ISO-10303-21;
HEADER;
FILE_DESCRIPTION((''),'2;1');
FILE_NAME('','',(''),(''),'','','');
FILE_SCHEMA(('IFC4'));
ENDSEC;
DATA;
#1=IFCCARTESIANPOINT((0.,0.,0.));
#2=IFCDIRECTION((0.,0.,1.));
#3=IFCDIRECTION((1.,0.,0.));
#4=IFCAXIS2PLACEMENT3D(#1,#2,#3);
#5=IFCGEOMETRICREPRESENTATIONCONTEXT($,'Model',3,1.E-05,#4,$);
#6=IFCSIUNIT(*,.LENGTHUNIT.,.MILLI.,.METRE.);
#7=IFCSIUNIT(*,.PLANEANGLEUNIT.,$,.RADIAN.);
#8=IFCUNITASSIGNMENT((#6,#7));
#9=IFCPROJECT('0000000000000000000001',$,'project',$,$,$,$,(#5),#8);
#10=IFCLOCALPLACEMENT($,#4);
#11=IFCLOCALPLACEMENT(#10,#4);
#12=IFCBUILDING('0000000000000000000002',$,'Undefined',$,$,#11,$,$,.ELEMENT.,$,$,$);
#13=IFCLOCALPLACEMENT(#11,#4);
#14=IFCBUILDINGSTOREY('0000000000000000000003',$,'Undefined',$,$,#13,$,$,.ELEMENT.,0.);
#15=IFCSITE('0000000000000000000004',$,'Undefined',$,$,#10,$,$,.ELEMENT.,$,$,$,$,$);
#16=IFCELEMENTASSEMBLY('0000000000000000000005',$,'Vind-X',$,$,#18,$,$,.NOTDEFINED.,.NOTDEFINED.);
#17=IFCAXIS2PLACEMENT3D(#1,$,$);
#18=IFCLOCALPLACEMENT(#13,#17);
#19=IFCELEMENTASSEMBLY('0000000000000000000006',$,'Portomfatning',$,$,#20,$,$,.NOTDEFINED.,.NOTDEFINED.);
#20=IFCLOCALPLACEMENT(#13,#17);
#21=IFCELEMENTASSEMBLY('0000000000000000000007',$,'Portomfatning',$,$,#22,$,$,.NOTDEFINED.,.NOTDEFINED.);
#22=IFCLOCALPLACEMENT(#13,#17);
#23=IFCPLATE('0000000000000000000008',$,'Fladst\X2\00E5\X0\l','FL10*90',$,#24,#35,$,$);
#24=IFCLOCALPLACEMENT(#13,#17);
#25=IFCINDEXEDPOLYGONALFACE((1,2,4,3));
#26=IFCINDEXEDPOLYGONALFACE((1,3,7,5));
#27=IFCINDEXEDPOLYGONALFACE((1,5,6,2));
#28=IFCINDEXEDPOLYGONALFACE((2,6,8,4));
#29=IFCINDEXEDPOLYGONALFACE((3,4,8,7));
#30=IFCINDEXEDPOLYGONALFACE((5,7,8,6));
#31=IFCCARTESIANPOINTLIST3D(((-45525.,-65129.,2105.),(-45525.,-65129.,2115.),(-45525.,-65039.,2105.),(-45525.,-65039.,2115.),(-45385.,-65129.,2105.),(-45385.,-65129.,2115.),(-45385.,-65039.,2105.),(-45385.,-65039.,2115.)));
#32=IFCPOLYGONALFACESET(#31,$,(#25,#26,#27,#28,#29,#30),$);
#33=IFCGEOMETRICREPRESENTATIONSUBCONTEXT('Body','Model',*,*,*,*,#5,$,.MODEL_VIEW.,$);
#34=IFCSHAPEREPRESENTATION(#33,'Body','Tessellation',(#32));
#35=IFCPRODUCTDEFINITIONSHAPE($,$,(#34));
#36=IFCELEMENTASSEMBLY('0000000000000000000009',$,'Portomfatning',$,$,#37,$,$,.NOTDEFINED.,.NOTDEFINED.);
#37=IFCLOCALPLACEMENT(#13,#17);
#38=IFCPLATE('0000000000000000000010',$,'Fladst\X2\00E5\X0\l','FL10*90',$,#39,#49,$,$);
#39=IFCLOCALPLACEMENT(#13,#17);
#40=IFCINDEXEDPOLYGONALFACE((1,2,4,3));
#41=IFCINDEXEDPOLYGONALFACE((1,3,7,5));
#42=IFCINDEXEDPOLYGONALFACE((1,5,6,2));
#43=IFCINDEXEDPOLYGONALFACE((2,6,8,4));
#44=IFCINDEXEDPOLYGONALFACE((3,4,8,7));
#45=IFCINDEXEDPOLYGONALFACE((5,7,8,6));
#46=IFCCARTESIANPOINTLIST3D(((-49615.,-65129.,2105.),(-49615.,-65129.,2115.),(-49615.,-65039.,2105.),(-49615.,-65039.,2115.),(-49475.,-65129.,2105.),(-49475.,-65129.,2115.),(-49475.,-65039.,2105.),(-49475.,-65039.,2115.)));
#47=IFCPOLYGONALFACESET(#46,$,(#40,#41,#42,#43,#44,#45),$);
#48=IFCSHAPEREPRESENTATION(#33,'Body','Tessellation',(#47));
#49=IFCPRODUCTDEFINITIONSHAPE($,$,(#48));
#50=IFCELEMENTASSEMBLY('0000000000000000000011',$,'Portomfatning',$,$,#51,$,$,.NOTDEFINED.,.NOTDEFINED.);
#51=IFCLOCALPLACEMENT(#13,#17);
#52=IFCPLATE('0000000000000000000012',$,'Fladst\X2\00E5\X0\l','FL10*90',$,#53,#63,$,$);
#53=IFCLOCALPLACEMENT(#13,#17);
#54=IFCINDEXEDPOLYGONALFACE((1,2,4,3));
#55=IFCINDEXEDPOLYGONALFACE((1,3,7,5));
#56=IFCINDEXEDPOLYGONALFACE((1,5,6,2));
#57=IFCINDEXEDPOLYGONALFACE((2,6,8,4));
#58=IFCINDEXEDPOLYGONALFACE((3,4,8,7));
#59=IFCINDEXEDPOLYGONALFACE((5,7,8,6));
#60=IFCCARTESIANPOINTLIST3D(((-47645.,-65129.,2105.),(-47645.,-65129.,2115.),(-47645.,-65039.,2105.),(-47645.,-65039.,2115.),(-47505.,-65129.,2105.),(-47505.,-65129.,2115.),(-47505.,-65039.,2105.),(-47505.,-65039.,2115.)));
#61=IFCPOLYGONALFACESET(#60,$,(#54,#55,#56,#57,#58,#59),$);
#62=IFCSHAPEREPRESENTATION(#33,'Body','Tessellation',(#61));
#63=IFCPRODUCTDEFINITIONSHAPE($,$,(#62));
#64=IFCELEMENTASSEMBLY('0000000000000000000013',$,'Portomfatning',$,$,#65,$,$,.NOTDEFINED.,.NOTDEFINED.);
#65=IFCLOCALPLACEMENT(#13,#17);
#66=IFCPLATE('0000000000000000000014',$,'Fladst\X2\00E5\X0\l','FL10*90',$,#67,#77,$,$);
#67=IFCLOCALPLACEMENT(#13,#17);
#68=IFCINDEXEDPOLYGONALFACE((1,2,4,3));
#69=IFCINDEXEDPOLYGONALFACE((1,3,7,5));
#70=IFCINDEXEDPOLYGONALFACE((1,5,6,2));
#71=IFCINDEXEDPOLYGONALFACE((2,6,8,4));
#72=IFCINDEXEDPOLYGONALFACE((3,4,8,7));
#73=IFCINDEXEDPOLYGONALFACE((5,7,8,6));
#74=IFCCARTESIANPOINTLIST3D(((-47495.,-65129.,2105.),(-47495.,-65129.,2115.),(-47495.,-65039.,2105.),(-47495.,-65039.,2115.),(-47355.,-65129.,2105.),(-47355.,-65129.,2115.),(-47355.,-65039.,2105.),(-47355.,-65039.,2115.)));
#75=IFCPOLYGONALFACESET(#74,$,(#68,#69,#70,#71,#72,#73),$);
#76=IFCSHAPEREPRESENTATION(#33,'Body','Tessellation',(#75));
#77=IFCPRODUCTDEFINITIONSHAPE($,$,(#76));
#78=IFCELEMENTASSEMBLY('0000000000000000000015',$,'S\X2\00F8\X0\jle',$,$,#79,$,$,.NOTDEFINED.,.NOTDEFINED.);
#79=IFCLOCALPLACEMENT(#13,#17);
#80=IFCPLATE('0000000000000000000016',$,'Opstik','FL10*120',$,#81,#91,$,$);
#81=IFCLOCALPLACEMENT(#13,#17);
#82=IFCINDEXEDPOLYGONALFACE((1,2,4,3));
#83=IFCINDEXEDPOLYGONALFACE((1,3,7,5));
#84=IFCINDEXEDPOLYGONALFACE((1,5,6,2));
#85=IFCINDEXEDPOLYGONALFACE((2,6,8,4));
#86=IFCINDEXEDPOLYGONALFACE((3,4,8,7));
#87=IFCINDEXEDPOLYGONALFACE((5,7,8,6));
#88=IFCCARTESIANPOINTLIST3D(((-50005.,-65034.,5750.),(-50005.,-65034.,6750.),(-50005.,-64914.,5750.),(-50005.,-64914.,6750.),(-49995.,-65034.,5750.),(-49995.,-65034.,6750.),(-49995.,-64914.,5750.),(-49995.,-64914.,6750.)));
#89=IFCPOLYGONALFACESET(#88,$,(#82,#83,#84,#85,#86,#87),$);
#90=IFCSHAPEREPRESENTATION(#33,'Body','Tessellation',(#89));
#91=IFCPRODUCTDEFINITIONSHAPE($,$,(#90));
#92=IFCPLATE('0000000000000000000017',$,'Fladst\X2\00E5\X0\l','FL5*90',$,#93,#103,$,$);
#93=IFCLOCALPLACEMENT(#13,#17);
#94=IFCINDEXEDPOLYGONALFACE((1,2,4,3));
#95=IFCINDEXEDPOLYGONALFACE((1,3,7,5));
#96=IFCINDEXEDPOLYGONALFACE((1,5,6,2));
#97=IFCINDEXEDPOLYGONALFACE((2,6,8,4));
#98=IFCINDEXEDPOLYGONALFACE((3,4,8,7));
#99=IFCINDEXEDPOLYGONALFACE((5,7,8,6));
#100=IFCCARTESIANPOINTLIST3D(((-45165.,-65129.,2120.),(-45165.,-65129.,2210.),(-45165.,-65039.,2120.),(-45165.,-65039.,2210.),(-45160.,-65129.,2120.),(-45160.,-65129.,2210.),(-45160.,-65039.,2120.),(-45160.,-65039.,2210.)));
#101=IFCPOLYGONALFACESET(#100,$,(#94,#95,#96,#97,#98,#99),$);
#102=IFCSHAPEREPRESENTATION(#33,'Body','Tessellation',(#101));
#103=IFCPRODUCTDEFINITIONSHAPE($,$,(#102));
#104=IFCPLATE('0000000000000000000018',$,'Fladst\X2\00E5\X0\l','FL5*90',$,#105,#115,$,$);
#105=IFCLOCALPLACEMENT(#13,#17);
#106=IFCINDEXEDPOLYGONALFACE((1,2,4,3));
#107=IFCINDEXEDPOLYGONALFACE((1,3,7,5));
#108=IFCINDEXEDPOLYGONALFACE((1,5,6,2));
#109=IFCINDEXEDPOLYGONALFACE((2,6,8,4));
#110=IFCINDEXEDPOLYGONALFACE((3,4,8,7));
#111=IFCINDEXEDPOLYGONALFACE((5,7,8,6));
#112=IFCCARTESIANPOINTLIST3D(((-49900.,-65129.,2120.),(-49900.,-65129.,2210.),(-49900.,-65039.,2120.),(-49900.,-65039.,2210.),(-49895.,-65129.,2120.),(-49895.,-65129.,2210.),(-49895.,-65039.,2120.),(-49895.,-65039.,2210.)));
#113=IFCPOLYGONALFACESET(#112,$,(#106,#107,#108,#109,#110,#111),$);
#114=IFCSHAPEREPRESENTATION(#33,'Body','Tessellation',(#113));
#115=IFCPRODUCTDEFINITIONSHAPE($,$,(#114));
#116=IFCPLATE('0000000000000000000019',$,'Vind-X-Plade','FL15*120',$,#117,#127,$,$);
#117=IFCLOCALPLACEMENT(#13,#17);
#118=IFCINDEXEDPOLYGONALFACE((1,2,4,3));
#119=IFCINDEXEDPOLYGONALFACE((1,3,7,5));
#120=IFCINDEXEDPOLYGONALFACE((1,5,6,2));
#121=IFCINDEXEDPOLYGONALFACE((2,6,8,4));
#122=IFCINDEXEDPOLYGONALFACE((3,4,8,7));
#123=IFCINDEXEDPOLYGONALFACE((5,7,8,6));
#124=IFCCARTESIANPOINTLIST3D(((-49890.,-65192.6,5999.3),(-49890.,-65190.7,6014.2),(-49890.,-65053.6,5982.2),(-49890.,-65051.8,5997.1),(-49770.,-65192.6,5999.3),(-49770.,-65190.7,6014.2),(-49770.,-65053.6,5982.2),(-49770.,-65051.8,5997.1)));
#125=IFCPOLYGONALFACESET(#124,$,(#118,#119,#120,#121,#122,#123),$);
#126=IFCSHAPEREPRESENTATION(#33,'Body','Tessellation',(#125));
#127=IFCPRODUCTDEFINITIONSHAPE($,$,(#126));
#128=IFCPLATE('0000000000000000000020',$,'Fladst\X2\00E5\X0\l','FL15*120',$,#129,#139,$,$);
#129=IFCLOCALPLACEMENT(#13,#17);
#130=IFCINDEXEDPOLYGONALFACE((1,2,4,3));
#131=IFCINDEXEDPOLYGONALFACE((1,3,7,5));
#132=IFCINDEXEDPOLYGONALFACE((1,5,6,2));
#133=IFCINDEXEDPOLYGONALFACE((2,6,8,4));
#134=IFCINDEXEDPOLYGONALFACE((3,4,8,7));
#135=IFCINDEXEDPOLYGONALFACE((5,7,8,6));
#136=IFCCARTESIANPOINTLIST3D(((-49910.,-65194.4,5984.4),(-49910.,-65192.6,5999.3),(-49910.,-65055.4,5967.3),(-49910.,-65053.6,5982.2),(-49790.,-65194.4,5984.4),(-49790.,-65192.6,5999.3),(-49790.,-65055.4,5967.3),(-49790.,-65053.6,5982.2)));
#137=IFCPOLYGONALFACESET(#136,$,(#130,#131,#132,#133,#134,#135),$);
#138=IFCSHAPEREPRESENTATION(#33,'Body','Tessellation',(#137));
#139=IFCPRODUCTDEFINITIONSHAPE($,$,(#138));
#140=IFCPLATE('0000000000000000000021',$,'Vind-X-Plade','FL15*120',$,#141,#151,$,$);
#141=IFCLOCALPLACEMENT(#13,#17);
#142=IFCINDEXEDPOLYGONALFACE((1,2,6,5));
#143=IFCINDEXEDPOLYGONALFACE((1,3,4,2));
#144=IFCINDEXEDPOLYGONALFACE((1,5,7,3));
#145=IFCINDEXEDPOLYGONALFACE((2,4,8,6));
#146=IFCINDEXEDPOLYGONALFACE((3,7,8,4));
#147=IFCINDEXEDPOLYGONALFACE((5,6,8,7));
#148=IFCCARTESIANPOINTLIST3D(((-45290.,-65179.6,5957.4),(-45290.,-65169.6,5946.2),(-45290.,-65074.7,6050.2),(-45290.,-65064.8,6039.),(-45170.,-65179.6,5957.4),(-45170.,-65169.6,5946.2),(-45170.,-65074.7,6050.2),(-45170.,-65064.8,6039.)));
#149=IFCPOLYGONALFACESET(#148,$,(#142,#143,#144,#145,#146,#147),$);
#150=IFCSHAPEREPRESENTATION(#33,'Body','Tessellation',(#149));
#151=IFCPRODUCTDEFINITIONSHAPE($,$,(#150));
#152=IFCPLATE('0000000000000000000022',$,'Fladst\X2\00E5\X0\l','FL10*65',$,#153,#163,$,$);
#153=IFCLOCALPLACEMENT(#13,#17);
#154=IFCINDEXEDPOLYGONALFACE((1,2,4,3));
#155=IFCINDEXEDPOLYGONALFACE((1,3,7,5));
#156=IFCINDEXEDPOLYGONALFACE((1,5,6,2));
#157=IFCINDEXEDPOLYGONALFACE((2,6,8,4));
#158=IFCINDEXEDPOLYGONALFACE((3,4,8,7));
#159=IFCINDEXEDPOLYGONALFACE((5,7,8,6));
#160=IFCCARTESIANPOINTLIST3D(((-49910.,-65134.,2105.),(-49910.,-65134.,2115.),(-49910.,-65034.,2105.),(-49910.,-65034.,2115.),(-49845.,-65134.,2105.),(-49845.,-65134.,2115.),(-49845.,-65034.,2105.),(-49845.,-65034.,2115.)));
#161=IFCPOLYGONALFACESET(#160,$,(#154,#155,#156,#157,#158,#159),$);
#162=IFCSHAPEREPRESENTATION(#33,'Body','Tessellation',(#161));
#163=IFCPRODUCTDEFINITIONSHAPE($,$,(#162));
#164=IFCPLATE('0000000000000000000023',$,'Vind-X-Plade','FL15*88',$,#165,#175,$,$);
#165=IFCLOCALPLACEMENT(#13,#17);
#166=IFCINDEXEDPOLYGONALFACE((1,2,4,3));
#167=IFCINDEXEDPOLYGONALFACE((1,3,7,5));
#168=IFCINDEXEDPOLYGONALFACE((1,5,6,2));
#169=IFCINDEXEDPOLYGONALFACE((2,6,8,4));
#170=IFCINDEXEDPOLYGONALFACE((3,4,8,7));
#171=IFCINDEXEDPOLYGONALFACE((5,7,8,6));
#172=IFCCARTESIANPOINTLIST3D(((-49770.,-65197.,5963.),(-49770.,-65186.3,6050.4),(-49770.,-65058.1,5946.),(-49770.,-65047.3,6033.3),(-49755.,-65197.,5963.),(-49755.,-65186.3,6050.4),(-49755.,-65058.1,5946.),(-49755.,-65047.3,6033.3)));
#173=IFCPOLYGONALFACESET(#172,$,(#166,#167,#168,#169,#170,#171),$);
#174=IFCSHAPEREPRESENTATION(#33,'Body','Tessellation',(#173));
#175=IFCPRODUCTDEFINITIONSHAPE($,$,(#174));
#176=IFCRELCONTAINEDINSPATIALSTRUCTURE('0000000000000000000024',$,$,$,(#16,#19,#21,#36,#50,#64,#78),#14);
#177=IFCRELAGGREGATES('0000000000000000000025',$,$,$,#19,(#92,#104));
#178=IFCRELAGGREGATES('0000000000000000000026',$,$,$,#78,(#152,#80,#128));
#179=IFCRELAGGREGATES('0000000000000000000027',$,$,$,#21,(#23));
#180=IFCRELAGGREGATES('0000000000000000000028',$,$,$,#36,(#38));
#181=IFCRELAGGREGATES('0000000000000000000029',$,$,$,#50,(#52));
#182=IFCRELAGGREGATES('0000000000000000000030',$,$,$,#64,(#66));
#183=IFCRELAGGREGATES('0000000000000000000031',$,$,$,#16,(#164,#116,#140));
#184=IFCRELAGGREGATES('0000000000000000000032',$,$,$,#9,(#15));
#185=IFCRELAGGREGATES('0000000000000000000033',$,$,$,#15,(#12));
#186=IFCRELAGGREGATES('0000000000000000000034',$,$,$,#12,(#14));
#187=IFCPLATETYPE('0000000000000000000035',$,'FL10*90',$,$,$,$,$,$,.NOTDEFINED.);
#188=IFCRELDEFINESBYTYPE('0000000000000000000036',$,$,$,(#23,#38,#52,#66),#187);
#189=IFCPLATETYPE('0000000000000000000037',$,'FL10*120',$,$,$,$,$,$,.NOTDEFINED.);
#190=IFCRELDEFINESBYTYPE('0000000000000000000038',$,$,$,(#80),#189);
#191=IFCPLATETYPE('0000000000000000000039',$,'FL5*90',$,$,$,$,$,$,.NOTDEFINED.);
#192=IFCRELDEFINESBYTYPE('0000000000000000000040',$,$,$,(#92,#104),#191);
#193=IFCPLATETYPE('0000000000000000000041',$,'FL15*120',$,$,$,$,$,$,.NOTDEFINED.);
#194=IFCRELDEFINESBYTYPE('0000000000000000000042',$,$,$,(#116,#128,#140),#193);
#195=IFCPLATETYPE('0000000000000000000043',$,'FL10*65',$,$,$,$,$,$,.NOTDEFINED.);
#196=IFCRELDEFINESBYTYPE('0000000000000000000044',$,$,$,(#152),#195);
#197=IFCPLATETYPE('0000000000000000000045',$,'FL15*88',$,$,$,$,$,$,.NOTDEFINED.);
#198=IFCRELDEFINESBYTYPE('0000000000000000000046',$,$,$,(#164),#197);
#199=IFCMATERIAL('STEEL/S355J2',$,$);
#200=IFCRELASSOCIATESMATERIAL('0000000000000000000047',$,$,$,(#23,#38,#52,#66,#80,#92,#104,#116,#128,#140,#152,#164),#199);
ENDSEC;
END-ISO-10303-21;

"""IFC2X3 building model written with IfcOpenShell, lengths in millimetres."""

from ifc_helpers import new_model, si_unit, frame, origin_with_axes, place, context, subcontext, project, spatial, polyline, outline, extrude, material, type_object, element, aggregate, save


model = new_model("IFC2X3")

# Units and contexts
model_context = context("Model", 3, precision=1e-05, world=origin_with_axes())
body_context = subcontext(model_context, "Body", "Model", "MODEL_VIEW")
ifc_project = project(units=[si_unit("LENGTHUNIT", "METRE", prefix="MILLI"), si_unit("PLANEANGLEUNIT", "RADIAN")], contexts=[model_context])

# Site, building, storey
site_placement = place(None, origin_with_axes())
site = spatial("IfcSite", under=ifc_project, at=site_placement, Name="Undefined", CompositionType="ELEMENT")
building_placement = place(site_placement, origin_with_axes())
building = spatial("IfcBuilding", under=site, at=building_placement, Name="Undefined", CompositionType="ELEMENT")
storey_placement = place(building_placement, origin_with_axes())
storey = spatial("IfcBuildingStorey", under=building, at=storey_placement, Name="Undefined", CompositionType="ELEMENT", Elevation=0.0)

# Element assemblies
assembly_1_placement = place(storey_placement, origin_with_axes())
assembly_1 = element("IfcElementAssembly", 1, at=assembly_1_placement, inside=storey, Name="Vind-X", AssemblyPlace="NOTDEFINED", PredefinedType="NOTDEFINED")
assembly_2_placement = place(storey_placement, origin_with_axes())
assembly_2 = element("IfcElementAssembly", 2, at=assembly_2_placement, inside=storey, Name="Portomfatning", AssemblyPlace="NOTDEFINED", PredefinedType="NOTDEFINED")

# Element assemblies, plates
assembly_3_placement = place(storey_placement, origin_with_axes())
assembly_3 = element("IfcElementAssembly", 3, at=assembly_3_placement, inside=storey, Name="Portomfatning", AssemblyPlace="NOTDEFINED", PredefinedType="NOTDEFINED")
ifc_material_1 = material(Name="STEEL/S355J2")
plate_type_1 = type_object("IfcPlateType", Name="FL10*90", PredefinedType="NOTDEFINED")
plate_1_placement = place(assembly_3_placement, frame((-45525.0, -65084.0, 2110.0), z_axis=(0.0, 0.0, -1.0), x_axis=(1.0, 0.0, 0.0)))
plate_1 = element("IfcPlate", 4, at=plate_1_placement, type_object=plate_type_1, material=ifc_material_1, Name="Fladstål", Description="FL10*90", context=body_context, shape_type="SweptSolid", body=[
    extrude(outline(polyline([(0.0, -45.0), (0.0, 45.0), (140.0, 45.0), (140.0, -45.0), (0.0, -45.0)])), frame((0.0, 0.0, -5.0), z_axis=(0.0, 0.0, 1.0), x_axis=(1.0, 0.0, 0.0)), (0.0, 0.0, 1.0), 10.0),
])
assembly_4_placement = place(storey_placement, origin_with_axes())
assembly_4 = element("IfcElementAssembly", 5, at=assembly_4_placement, inside=storey, Name="Portomfatning", AssemblyPlace="NOTDEFINED", PredefinedType="NOTDEFINED")
plate_2_placement = place(assembly_4_placement, frame((-49475.0, -65084.0, 2110.0), z_axis=(0.0, 0.0, -1.0), x_axis=(-1.0, 0.0, 0.0)))
plate_2 = element("IfcPlate", 6, at=plate_2_placement, type_object=plate_type_1, material=ifc_material_1, Name="Fladstål", Description="FL10*90", context=body_context, shape_type="SweptSolid", body=[
    extrude(outline(polyline([(0.0, -45.0), (0.0, 45.0), (140.0, 45.0), (140.0, -45.0), (0.0, -45.0)])), frame((0.0, 0.0, -5.0), z_axis=(0.0, 0.0, 1.0), x_axis=(1.0, 0.0, 0.0)), (0.0, 0.0, 1.0), 10.0),
])
assembly_5_placement = place(storey_placement, origin_with_axes())
assembly_5 = element("IfcElementAssembly", 7, at=assembly_5_placement, inside=storey, Name="Portomfatning", AssemblyPlace="NOTDEFINED", PredefinedType="NOTDEFINED")
plate_3_placement = place(assembly_5_placement, frame((-47645.0, -65084.0, 2110.0), z_axis=(0.0, 0.0, -1.0), x_axis=(1.0, 0.0, 0.0)))
plate_3 = element("IfcPlate", 8, at=plate_3_placement, type_object=plate_type_1, material=ifc_material_1, Name="Fladstål", Description="FL10*90", context=body_context, shape_type="SweptSolid", body=[
    extrude(outline(polyline([(0.0, -45.0), (0.0, 45.0), (140.0, 45.0), (140.0, -45.0), (0.0, -45.0)])), frame((0.0, 0.0, -5.0), z_axis=(0.0, 0.0, 1.0), x_axis=(1.0, 0.0, 0.0)), (0.0, 0.0, 1.0), 10.0),
])
assembly_6_placement = place(storey_placement, origin_with_axes())
assembly_6 = element("IfcElementAssembly", 9, at=assembly_6_placement, inside=storey, Name="Portomfatning", AssemblyPlace="NOTDEFINED", PredefinedType="NOTDEFINED")
plate_4_placement = place(assembly_6_placement, frame((-47355.0, -65084.0, 2110.0), z_axis=(0.0, 0.0, -1.0), x_axis=(-1.0, 0.0, 0.0)))
plate_4 = element("IfcPlate", 10, at=plate_4_placement, type_object=plate_type_1, material=ifc_material_1, Name="Fladstål", Description="FL10*90", context=body_context, shape_type="SweptSolid", body=[
    extrude(outline(polyline([(0.0, -45.0), (0.0, 45.0), (140.0, 45.0), (140.0, -45.0), (0.0, -45.0)])), frame((0.0, 0.0, -5.0), z_axis=(0.0, 0.0, 1.0), x_axis=(1.0, 0.0, 0.0)), (0.0, 0.0, 1.0), 10.0),
])
assembly_7_placement = place(storey_placement, origin_with_axes())
assembly_7 = element("IfcElementAssembly", 11, at=assembly_7_placement, inside=storey, Name="Søjle", AssemblyPlace="NOTDEFINED", PredefinedType="NOTDEFINED")
plate_type_2 = type_object("IfcPlateType", Name="FL10*120", PredefinedType="NOTDEFINED")
plate_5_placement = place(assembly_7_placement, frame((-50000.0, -65034.0, 5750.0), z_axis=(-1.0, 0.0, 0.0), x_axis=(0.0, 0.0, 1.0)))
plate_5 = element("IfcPlate", 12, at=plate_5_placement, type_object=plate_type_2, material=ifc_material_1, Name="Opstik", Description="FL10*120", context=body_context, shape_type="SweptSolid", body=[
    extrude(outline(polyline([(0.0, 0.0), (1000.0, 0.0), (1000.0, 120.0), (1000.0, 120.0), (0.0, 120.0), (0.0, 120.0), (0.0, 0.0)])), frame((0.0, 0.0, -5.0), z_axis=(0.0, 0.0, 1.0), x_axis=(1.0, 0.0, 0.0)), (0.0, 0.0, 1.0), 10.0),
])

# Plates
plate_type_3 = type_object("IfcPlateType", Name="FL5*90", PredefinedType="NOTDEFINED")
plate_6_placement = place(assembly_2_placement, frame((-45162.5, -65039.0, 2120.0), z_axis=(1.0, -0.000185, 0.0), x_axis=(0.0, 0.0, 1.0)))
plate_6 = element("IfcPlate", 13, at=plate_6_placement, type_object=plate_type_3, material=ifc_material_1, Name="Fladstål", Description="FL5*90", context=body_context, shape_type="SweptSolid", body=[
    extrude(outline(polyline([(0.0, 0.0), (90.0, 0.0), (90.0, 90.0), (0.0, 90.0), (0.0, 0.0)])), frame((0.0, 0.0, -2.5), z_axis=(0.0, 0.0, 1.0), x_axis=(1.0, 0.0, 0.0)), (0.0, 0.0, 1.0), 5.0),
])
plate_7_placement = place(assembly_2_placement, frame((-49897.5, -65039.0, 2210.0), z_axis=(-1.0, -0.000185, 0.0), x_axis=(0.0, 0.0, -1.0)))
plate_7 = element("IfcPlate", 14, at=plate_7_placement, type_object=plate_type_3, material=ifc_material_1, Name="Fladstål", Description="FL5*90", context=body_context, shape_type="SweptSolid", body=[
    extrude(outline(polyline([(0.0, 0.0), (90.0, 0.0), (90.0, 90.0), (0.0, 90.0), (0.0, 0.0)])), frame((0.0, 0.0, -2.5), z_axis=(0.0, 0.0, 1.0), x_axis=(1.0, 0.0, 0.0)), (0.0, 0.0, 1.0), 5.0),
])
aggregate(assembly_2, [plate_6, plate_7])
plate_type_4 = type_object("IfcPlateType", Name="FL15*120", PredefinedType="NOTDEFINED")
plate_8_placement = place(assembly_1_placement, frame((-49890.0, -65122.2, 5998.2), z_axis=(0.0, -0.121869, -0.992546), x_axis=(1.0, 0.0, 0.0)))
plate_8 = element("IfcPlate", 15, at=plate_8_placement, type_object=plate_type_4, material=ifc_material_1, Name="Vind-X-Plade", Description="FL15*120", context=body_context, shape_type="SweptSolid", body=[
    extrude(outline(polyline([(0.0, -70.0), (0.0, 70.0), (120.0, 70.0), (120.0, -70.0), (0.0, -70.0)])), frame((0.0, 0.0, -7.5), z_axis=(0.0, 0.0, 1.0), x_axis=(1.0, 0.0, 0.0)), (0.0, 0.0, 1.0), 15.0),
])
plate_9_placement = place(assembly_7_placement, frame((-49910.0, -65054.5, 5974.8), z_axis=(0.0, 0.121869, 0.992546), x_axis=(0.0, -0.992546, 0.121869)))
plate_9 = element("IfcPlate", 16, at=plate_9_placement, type_object=plate_type_4, material=ifc_material_1, Name="Fladstål", Description="FL15*120", context=body_context, shape_type="SweptSolid", body=[
    extrude(outline(polyline([(0.0, 0.0), (140.0, 0.0), (140.0, 120.0), (0.0, 120.0), (0.0, 0.0)])), frame((0.0, 0.0, -7.5), z_axis=(0.0, 0.0, 1.0), x_axis=(1.0, 0.0, 0.0)), (0.0, 0.0, 1.0), 15.0),
])
plate_10_placement = place(assembly_1_placement, frame((-45170.0, -65122.2, 5998.2), z_axis=(0.0, 0.66262, -0.748956), x_axis=(-1.0, 0.0, 0.0)))
plate_10 = element("IfcPlate", 17, at=plate_10_placement, type_object=plate_type_4, material=ifc_material_1, Name="Vind-X-Plade", Description="FL15*120", context=body_context, shape_type="SweptSolid", body=[
    extrude(outline(polyline([(0.0, -70.0), (0.0, 70.0), (120.0, 70.0), (120.0, -70.0), (0.0, -70.0)])), frame((0.0, 0.0, -7.5), z_axis=(0.0, 0.0, 1.0), x_axis=(1.0, 0.0, 0.0)), (0.0, 0.0, 1.0), 15.0),
])
plate_type_5 = type_object("IfcPlateType", Name="FL10*65", PredefinedType="NOTDEFINED")
plate_11_placement = place(assembly_7_placement, frame((-49910.0, -65134.0, 2110.0), z_axis=(0.0, 0.0, 1.0), x_axis=(1.0, 0.0, 0.0)))
plate_11 = element("IfcPlate", 18, at=plate_11_placement, type_object=plate_type_5, material=ifc_material_1, Name="Fladstål", Description="FL10*65", context=body_context, shape_type="SweptSolid", body=[
    extrude(outline(polyline([(0.0, 0.0), (65.0, 0.0), (65.0, 100.0), (0.0, 100.0), (0.0, 0.0)])), frame((0.0, 0.0, -5.0), z_axis=(0.0, 0.0, 1.0), x_axis=(1.0, 0.0, 0.0)), (0.0, 0.0, 1.0), 10.0),
])
plate_type_6 = type_object("IfcPlateType", Name="FL15*88", PredefinedType="NOTDEFINED")
plate_12_placement = place(assembly_1_placement, frame((-49762.5, -65058.1, 5946.0), z_axis=(-1.0, 0.0, 0.0), x_axis=(0.0, -0.992546, 0.121869)))
plate_12 = element("IfcPlate", 19, at=plate_12_placement, type_object=plate_type_6, material=ifc_material_1, Name="Vind-X-Plade", Description="FL15*88", context=body_context, shape_type="SweptSolid", body=[
    extrude(outline(polyline([(0.0, 0.0), (140.0, 0.0), (140.0, 88.0), (0.0, 88.0), (0.0, 0.0)])), frame((0.0, 0.0, -7.5), z_axis=(0.0, 0.0, 1.0), x_axis=(1.0, 0.0, 0.0)), (0.0, 0.0, 1.0), 15.0),
])

aggregate(assembly_7, [plate_11, plate_5, plate_9])
aggregate(assembly_3, [plate_1])
aggregate(assembly_4, [plate_2])
aggregate(assembly_5, [plate_3])
aggregate(assembly_6, [plate_4])
aggregate(assembly_1, [plate_12, plate_8, plate_10])

save(model, "model.ifc")
